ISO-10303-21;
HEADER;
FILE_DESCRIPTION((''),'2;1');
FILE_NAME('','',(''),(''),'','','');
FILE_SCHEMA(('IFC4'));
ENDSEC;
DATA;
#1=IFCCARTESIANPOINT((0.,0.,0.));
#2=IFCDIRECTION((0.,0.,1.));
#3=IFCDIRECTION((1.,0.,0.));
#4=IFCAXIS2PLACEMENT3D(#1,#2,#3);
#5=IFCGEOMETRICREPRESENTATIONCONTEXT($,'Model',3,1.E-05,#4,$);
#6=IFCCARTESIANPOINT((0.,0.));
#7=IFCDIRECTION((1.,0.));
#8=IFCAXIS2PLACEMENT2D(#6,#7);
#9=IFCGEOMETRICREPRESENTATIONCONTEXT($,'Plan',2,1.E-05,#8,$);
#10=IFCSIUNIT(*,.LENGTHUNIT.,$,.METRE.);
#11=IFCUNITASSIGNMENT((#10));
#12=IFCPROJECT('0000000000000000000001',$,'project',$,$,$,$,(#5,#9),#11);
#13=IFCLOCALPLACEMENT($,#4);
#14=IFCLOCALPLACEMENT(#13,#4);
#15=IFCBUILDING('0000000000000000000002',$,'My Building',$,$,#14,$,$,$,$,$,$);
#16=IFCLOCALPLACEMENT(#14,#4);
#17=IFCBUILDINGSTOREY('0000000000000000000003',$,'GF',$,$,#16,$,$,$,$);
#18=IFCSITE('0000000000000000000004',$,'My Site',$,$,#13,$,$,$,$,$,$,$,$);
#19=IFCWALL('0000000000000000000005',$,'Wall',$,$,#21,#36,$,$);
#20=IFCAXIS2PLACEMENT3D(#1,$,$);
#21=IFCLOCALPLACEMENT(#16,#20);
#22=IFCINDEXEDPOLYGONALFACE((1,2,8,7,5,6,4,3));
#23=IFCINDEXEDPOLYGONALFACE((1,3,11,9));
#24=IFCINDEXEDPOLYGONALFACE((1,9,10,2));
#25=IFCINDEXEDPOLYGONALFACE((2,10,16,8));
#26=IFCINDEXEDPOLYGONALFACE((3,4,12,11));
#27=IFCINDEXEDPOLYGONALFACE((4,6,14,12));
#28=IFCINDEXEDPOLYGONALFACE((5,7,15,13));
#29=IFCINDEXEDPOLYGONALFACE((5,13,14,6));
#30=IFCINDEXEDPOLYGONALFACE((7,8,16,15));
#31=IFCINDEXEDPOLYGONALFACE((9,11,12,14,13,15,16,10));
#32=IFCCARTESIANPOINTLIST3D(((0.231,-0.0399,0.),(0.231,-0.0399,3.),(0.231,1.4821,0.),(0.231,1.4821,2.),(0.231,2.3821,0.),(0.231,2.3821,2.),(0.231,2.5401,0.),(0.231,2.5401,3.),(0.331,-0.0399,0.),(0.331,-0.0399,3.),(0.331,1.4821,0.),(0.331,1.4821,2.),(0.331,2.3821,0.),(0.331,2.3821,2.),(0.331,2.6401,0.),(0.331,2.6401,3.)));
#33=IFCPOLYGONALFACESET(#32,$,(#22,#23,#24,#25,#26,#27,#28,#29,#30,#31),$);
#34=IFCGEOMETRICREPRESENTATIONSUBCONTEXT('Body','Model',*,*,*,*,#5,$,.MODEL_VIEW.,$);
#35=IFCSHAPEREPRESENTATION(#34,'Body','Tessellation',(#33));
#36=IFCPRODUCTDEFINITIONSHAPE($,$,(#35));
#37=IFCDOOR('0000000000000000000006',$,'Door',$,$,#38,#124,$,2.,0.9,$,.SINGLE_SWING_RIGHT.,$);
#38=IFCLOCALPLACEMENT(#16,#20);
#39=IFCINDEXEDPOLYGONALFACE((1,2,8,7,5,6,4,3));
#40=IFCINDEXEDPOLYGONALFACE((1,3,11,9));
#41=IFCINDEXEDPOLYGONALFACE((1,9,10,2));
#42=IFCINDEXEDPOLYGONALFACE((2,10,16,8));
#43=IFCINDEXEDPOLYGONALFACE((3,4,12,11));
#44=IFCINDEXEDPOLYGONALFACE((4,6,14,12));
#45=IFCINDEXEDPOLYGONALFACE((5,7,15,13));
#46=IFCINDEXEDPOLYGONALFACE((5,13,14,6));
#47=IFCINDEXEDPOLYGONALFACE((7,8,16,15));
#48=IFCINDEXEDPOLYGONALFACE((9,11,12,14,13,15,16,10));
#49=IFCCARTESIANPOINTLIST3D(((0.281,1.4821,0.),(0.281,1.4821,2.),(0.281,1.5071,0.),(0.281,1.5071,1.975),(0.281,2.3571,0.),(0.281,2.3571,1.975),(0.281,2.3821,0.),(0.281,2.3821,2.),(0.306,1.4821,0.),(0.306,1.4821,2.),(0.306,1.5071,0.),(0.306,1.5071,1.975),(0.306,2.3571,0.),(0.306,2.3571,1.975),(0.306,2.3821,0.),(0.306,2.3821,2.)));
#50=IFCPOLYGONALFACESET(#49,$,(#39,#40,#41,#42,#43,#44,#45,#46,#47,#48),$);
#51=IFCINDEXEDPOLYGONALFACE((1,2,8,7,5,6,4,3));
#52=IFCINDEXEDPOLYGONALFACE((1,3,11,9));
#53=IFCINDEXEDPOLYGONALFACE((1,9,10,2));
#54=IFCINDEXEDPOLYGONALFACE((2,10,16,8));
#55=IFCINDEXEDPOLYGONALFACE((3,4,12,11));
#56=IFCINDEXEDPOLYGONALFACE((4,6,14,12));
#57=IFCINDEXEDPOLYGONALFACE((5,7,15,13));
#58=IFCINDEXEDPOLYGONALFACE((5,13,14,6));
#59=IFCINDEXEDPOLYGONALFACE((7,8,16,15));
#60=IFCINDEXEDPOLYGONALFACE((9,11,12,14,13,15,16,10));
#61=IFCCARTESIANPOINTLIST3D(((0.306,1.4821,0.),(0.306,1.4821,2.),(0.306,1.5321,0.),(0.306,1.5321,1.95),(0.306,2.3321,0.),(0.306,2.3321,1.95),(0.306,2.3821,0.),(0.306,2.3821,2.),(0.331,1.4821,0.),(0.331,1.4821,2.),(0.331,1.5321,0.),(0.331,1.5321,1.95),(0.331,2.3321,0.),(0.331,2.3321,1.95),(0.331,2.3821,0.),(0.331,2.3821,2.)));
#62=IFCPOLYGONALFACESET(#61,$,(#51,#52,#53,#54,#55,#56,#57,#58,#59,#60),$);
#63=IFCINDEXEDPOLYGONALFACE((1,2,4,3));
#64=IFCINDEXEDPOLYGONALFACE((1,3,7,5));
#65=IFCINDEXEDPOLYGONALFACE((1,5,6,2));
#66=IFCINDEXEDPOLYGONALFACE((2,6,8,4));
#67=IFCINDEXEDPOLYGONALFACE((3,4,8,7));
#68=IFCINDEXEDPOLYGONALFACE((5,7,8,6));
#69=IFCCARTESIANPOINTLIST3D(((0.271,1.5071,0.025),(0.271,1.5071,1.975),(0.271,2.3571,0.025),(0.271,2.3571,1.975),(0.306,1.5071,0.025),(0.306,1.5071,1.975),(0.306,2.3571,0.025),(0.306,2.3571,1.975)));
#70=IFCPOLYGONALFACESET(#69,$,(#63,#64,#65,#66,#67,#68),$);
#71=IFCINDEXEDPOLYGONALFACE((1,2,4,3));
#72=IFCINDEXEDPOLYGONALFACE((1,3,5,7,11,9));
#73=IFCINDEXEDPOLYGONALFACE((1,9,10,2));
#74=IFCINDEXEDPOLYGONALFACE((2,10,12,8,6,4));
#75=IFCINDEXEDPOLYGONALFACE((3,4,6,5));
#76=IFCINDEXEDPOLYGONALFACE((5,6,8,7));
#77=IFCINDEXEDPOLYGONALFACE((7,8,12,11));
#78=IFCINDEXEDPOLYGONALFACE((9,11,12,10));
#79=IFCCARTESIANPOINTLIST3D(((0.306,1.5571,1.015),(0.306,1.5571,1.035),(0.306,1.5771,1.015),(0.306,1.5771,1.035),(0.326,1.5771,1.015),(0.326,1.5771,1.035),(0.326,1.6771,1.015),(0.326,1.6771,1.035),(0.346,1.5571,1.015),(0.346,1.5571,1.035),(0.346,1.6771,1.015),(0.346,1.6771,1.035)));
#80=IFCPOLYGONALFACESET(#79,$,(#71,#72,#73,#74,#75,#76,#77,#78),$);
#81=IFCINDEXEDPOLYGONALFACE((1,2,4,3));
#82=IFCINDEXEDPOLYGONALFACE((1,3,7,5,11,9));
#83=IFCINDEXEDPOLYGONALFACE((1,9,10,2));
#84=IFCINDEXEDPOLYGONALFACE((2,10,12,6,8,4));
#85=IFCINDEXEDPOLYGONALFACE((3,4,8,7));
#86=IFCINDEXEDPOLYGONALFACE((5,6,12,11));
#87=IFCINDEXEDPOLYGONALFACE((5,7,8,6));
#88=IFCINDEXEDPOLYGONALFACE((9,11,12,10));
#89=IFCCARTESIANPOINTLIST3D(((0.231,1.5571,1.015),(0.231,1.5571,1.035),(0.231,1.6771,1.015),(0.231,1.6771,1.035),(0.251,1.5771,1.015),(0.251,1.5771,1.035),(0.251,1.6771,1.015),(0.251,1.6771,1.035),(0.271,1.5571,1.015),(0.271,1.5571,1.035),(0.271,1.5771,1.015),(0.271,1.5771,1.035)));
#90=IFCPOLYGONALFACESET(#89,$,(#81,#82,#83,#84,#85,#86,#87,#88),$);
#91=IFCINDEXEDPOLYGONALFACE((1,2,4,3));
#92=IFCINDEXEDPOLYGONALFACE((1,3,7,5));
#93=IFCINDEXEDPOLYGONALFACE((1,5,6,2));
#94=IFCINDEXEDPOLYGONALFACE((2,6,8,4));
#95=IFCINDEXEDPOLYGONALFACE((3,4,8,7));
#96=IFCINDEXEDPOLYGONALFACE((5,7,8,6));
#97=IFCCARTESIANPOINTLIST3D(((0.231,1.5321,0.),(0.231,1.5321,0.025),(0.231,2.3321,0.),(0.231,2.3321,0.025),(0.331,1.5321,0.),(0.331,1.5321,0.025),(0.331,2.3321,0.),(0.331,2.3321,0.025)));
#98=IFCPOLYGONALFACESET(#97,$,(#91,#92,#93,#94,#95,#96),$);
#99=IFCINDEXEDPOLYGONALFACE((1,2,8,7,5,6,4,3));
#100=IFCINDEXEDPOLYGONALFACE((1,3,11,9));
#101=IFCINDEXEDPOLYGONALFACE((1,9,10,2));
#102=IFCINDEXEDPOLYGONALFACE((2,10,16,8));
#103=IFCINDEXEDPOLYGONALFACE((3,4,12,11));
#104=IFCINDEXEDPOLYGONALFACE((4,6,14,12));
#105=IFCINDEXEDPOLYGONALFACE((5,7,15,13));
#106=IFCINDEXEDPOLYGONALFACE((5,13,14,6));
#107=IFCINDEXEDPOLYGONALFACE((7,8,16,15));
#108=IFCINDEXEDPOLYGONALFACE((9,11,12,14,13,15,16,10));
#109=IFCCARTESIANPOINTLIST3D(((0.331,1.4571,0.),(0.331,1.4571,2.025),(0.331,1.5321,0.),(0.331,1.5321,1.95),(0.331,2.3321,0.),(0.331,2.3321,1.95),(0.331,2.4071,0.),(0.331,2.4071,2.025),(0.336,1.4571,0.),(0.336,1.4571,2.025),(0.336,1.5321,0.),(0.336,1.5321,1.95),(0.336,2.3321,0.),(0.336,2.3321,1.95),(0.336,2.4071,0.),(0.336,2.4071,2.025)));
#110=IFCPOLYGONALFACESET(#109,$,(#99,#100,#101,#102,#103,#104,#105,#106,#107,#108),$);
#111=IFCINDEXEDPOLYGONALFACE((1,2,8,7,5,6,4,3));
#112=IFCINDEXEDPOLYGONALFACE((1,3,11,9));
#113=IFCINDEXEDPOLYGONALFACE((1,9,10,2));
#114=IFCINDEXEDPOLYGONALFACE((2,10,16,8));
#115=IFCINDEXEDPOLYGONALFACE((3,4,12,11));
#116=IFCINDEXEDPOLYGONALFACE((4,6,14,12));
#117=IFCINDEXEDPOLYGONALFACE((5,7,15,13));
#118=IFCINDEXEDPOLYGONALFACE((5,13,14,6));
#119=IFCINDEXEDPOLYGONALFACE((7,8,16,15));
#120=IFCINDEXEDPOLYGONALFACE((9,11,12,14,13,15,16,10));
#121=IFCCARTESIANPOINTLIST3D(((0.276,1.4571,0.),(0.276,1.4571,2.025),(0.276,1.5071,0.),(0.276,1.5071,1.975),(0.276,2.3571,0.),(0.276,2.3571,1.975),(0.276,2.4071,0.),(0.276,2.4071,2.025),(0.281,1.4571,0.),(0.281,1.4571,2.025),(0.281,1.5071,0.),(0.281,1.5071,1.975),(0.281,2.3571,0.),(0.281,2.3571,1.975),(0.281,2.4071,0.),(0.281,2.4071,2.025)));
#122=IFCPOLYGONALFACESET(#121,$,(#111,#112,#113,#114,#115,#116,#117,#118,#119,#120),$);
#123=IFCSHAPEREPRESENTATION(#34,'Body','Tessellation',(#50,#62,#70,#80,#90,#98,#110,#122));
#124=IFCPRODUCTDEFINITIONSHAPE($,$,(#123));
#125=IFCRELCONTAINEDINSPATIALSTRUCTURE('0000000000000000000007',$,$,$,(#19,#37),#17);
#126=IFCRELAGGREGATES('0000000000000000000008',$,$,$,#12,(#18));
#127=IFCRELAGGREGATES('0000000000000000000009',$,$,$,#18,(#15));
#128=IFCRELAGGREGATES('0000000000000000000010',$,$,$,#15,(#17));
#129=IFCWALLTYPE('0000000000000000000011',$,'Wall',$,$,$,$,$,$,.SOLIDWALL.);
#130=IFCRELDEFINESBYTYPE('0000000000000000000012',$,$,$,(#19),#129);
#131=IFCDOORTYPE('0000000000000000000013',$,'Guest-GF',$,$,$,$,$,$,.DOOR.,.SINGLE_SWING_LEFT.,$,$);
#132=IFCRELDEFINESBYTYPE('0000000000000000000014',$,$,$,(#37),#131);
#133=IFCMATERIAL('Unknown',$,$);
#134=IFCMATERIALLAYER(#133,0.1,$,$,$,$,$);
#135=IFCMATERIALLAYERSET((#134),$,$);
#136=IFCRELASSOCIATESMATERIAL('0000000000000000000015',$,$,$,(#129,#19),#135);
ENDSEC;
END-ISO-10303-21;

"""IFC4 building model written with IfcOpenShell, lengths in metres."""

from ifc_helpers import new_model, entity, si_unit, frame, origin_with_axes, origin_2d_with_axis, place, context, subcontext, project, spatial, line, indexed_curve, outline, extrude, shape, source, transform, mapped, material, layer, layer_set, layer_usage, type_object, type_shapes, element, fill, save


model = new_model("IFC4")

# Units and contexts
model_context = context("Model", 3, precision=1e-05, world=origin_with_axes())
plan_context = context("Plan", 2, precision=1e-05, world=origin_2d_with_axis())
body_context_1 = subcontext(model_context, "Body", "Model", "MODEL_VIEW")
body_context_2 = subcontext(plan_context, "Body", "Plan", "PLAN_VIEW")
ifc_project = project(units=[si_unit("LENGTHUNIT", "METRE")], contexts=[model_context, plan_context])

# Site, building, storey
site_placement = place(None, origin_with_axes())
site = spatial("IfcSite", under=ifc_project, at=site_placement, Name="My Site")
building_placement = place(site_placement, origin_with_axes())
building = spatial("IfcBuilding", under=site, at=building_placement, Name="My Building")
storey_placement = place(building_placement, origin_with_axes())
storey = spatial("IfcBuildingStorey", under=building, at=storey_placement, Name="GF")

# Shared definitions
ifc_material = material(Name="Unknown")

# Shared definitions
ifc_layer_1 = layer(ifc_material, 0.1)
ifc_layer_set_1 = layer_set([ifc_layer_1])
wall_type = type_object("IfcWallType", Name="Wall", PredefinedType="SOLIDWALL", material=ifc_layer_set_1)

# Wall, opening, door
ifc_layer_usage_1 = layer_usage(ifc_layer_set_1, "AXIS2", "POSITIVE", 0.0)
wall_1_placement = place(storey_placement, frame((0.331, -0.0399, 0.0), z_axis=(0.0, 0.0, 1.0), x_axis=(0.0, 1.0, 0.0)))
wall_1 = element("IfcWall", 1, at=wall_1_placement, inside=storey, type_object=wall_type, material=ifc_layer_usage_1, Name="Wall", context=body_context_1, shape_type="SweptSolid", body=[
    extrude(outline(indexed_curve([(0.0, 0.0), (0.0, 0.1), (2.58, 0.1), (2.68, 0.0)], segments=[line(1, 2, 3, 4, 1)])), origin_with_axes(), (0.0, 0.0, 1.0), 3.0),
])
shared_shape_1 = source(origin_with_axes(), body_context_1, "Body", "SweptSolid", [
    extrude(outline(indexed_curve([(0.0, 0.0), (0.9, 0.0), (0.9, 2.0), (0.0, 2.0)], segments=[line(1, 2, 3, 4, 1)])), frame((0.0, -0.6, 0.0), z_axis=(0.0, -1.0, 0.0), x_axis=(1.0, 0.0, 0.0)), (0.0, 0.0, -1.0), 1.2),
])
opening_1_placement = place(wall_1_placement, frame((1.522, 0.0, 0.0), z_axis=(0.0, 0.0, 1.0), x_axis=(1.0, 0.0, 0.0)))
opening_1 = element("IfcOpeningElement", 2, at=opening_1_placement, cuts=wall_1, PredefinedType="OPENING", context=body_context_1, shape_type="MappedRepresentation", body=[
    mapped(shared_shape_1, transform((0.0, 0.0, 0.0), x_axis=(1.0, 0.0, 0.0), y_axis=(0.0, 1.0, 0.0), z_axis=(0.0, 0.0, 1.0), scale=1.0)),
])
door_type_1 = type_object("IfcDoorType", Name="Guest-GF", OperationType="SINGLE_SWING_LEFT", PredefinedType="DOOR")
shared_shape_2 = source(origin_with_axes(), body_context_1, "Body", "SweptSolid", [
    extrude(outline(indexed_curve([(0.0, 0.0), (0.0, 2.0), (0.9, 2.0), (0.9, 0.0), (0.875, 0.0), (0.875, 1.975), (0.025, 1.975), (0.025, 0.0)], segments=[line(1, 2, 3, 4, 5, 6, 7, 8, 1)])), frame((0.0, 0.025, 0.0), z_axis=(0.0, -1.0, 0.0), x_axis=(1.0, 0.0, 0.0)), (0.0, 0.0, -1.0), 0.025),
    extrude(outline(indexed_curve([(0.0, 0.0), (0.0, 2.0), (0.9, 2.0), (0.9, 0.0), (0.85, 0.0), (0.85, 1.95), (0.05, 1.95), (0.05, 0.0)], segments=[line(1, 2, 3, 4, 5, 6, 7, 8, 1)])), frame((0.0, 0.0, 0.0), z_axis=(0.0, -1.0, 0.0), x_axis=(1.0, 0.0, 0.0)), (0.0, 0.0, -1.0), 0.025),
    extrude(outline(indexed_curve([(0.0, 0.0), (0.85, 0.0), (0.85, 0.035), (0.0, 0.035)], segments=[line(1, 2, 3, 4, 1)])), frame((0.025, 0.025, 0.025), z_axis=(0.0, 0.0, 1.0), x_axis=(1.0, 0.0, 0.0)), (0.0, 0.0, 1.0), 1.95),
    extrude(outline(indexed_curve([(0.0, 0.0), (0.0, -0.04), (0.12, -0.04), (0.12, -0.02), (0.02, -0.02), (0.02, 0.0)], segments=[line(1, 2, 3, 4, 5, 6, 1)])), frame((0.075, 0.025, 1.015), z_axis=(0.0, 0.0, 1.0), x_axis=(1.0, 0.0, 0.0)), (0.0, 0.0, 1.0), 0.02),
    extrude(outline(indexed_curve([(0.0, 0.0), (0.0, 0.04), (0.12, 0.04), (0.12, 0.02), (0.02, 0.02), (0.02, 0.0)], segments=[line(1, 2, 3, 4, 5, 6, 1)])), frame((0.075, 0.06, 1.015), z_axis=(0.0, 0.0, 1.0), x_axis=(1.0, 0.0, 0.0)), (0.0, 0.0, 1.0), 0.02),
    extrude(outline(indexed_curve([(0.0, 0.0), (0.8, 0.0), (0.8, 0.1), (0.0, 0.1)], segments=[line(1, 2, 3, 4, 1)])), frame((0.05, 0.0, 0.0), z_axis=(0.0, 0.0, 1.0), x_axis=(1.0, 0.0, 0.0)), (0.0, 0.0, 1.0), 0.025),
    extrude(outline(indexed_curve([(0.0, 0.0), (0.0, 2.025), (0.95, 2.025), (0.95, 0.0), (0.875, 0.0), (0.875, 1.95), (0.075, 1.95), (0.075, 0.0)], segments=[line(1, 2, 3, 4, 5, 6, 7, 8, 1)])), frame((-0.025, -0.005, 0.0), z_axis=(0.0, -1.0, 0.0), x_axis=(1.0, 0.0, 0.0)), (0.0, 0.0, -1.0), 0.005),
    extrude(outline(indexed_curve([(0.0, 0.0), (0.0, 2.025), (0.95, 2.025), (0.95, 0.0), (0.9, 0.0), (0.9, 1.975), (0.05, 1.975), (0.05, 0.0)], segments=[line(1, 2, 3, 4, 5, 6, 7, 8, 1)])), frame((-0.025, 0.05, 0.0), z_axis=(0.0, -1.0, 0.0), x_axis=(1.0, 0.0, 0.0)), (0.0, 0.0, -1.0), 0.005),
])
shared_shape_3 = source(origin_with_axes(), body_context_2, "Body", "Curve2D", [
    entity("IfcIndexedPolyCurve", entity("IfcCartesianPointList2D", [[0.0, 0.0], [0.0, 0.05], [0.025, 0.05], [0.025, 0.025], [0.05, 0.025], [0.05, 0.0]]), [entity("IfcLineIndex", [1, 2, 3, 4, 5, 6, 1])]),
    entity("IfcIndexedPolyCurve", entity("IfcCartesianPointList2D", [[0.9, 0.0], [0.9, 0.05], [0.875, 0.05], [0.875, 0.025], [0.85, 0.025], [0.85, 0.0]]), [entity("IfcLineIndex", [1, 2, 3, 4, 5, 6, 1])]),
    entity("IfcTrimmedCurve", entity("IfcEllipse", entity("IfcAxis2Placement2D", entity("IfcCartesianPoint", [0.84, 0.05]), entity("IfcDirection", [1.0, 0.0])), 0.815, 0.85), [entity("IfcCartesianPoint", [0.84, 0.9])], [entity("IfcCartesianPoint", [0.025, 0.05])], True, "CARTESIAN"),
    entity("IfcIndexedPolyCurve", entity("IfcCartesianPointList2D", [[0.875, 0.05], [0.84, 0.05], [0.84, 0.9], [0.875, 0.9]]), [entity("IfcLineIndex", [1, 2, 3, 4, 1])]),
])
type_shapes(door_type_1, [shared_shape_2, shared_shape_3])
door_1_placement = place(opening_1_placement, frame((0.0, 0.0, 0.0), z_axis=(0.0, 0.0, 1.0), x_axis=(1.0, 0.0, 0.0)))
door_1 = element("IfcDoor", 3, at=door_1_placement, inside=storey, type_object=door_type_1, Name="Door", OperationType="SINGLE_SWING_RIGHT", OverallHeight=2.0, OverallWidth=0.9, shapes=[
    shape(body_context_1, "Body", "MappedRepresentation", [mapped(shared_shape_2, transform((0.0, 0.0, 0.0), x_axis=(1.0, 0.0, 0.0), y_axis=(0.0, 1.0, 0.0), z_axis=(0.0, 0.0, 1.0), scale=1.0))]),
    shape(body_context_2, "Body", "MappedRepresentation", [mapped(shared_shape_3, transform((0.0, 0.0, 0.0), x_axis=(1.0, 0.0, 0.0), y_axis=(0.0, 1.0, 0.0), z_axis=(0.0, 0.0, 1.0), scale=1.0))]),
])
fill(opening_1, door_1)

save(model, "model.ifc")
